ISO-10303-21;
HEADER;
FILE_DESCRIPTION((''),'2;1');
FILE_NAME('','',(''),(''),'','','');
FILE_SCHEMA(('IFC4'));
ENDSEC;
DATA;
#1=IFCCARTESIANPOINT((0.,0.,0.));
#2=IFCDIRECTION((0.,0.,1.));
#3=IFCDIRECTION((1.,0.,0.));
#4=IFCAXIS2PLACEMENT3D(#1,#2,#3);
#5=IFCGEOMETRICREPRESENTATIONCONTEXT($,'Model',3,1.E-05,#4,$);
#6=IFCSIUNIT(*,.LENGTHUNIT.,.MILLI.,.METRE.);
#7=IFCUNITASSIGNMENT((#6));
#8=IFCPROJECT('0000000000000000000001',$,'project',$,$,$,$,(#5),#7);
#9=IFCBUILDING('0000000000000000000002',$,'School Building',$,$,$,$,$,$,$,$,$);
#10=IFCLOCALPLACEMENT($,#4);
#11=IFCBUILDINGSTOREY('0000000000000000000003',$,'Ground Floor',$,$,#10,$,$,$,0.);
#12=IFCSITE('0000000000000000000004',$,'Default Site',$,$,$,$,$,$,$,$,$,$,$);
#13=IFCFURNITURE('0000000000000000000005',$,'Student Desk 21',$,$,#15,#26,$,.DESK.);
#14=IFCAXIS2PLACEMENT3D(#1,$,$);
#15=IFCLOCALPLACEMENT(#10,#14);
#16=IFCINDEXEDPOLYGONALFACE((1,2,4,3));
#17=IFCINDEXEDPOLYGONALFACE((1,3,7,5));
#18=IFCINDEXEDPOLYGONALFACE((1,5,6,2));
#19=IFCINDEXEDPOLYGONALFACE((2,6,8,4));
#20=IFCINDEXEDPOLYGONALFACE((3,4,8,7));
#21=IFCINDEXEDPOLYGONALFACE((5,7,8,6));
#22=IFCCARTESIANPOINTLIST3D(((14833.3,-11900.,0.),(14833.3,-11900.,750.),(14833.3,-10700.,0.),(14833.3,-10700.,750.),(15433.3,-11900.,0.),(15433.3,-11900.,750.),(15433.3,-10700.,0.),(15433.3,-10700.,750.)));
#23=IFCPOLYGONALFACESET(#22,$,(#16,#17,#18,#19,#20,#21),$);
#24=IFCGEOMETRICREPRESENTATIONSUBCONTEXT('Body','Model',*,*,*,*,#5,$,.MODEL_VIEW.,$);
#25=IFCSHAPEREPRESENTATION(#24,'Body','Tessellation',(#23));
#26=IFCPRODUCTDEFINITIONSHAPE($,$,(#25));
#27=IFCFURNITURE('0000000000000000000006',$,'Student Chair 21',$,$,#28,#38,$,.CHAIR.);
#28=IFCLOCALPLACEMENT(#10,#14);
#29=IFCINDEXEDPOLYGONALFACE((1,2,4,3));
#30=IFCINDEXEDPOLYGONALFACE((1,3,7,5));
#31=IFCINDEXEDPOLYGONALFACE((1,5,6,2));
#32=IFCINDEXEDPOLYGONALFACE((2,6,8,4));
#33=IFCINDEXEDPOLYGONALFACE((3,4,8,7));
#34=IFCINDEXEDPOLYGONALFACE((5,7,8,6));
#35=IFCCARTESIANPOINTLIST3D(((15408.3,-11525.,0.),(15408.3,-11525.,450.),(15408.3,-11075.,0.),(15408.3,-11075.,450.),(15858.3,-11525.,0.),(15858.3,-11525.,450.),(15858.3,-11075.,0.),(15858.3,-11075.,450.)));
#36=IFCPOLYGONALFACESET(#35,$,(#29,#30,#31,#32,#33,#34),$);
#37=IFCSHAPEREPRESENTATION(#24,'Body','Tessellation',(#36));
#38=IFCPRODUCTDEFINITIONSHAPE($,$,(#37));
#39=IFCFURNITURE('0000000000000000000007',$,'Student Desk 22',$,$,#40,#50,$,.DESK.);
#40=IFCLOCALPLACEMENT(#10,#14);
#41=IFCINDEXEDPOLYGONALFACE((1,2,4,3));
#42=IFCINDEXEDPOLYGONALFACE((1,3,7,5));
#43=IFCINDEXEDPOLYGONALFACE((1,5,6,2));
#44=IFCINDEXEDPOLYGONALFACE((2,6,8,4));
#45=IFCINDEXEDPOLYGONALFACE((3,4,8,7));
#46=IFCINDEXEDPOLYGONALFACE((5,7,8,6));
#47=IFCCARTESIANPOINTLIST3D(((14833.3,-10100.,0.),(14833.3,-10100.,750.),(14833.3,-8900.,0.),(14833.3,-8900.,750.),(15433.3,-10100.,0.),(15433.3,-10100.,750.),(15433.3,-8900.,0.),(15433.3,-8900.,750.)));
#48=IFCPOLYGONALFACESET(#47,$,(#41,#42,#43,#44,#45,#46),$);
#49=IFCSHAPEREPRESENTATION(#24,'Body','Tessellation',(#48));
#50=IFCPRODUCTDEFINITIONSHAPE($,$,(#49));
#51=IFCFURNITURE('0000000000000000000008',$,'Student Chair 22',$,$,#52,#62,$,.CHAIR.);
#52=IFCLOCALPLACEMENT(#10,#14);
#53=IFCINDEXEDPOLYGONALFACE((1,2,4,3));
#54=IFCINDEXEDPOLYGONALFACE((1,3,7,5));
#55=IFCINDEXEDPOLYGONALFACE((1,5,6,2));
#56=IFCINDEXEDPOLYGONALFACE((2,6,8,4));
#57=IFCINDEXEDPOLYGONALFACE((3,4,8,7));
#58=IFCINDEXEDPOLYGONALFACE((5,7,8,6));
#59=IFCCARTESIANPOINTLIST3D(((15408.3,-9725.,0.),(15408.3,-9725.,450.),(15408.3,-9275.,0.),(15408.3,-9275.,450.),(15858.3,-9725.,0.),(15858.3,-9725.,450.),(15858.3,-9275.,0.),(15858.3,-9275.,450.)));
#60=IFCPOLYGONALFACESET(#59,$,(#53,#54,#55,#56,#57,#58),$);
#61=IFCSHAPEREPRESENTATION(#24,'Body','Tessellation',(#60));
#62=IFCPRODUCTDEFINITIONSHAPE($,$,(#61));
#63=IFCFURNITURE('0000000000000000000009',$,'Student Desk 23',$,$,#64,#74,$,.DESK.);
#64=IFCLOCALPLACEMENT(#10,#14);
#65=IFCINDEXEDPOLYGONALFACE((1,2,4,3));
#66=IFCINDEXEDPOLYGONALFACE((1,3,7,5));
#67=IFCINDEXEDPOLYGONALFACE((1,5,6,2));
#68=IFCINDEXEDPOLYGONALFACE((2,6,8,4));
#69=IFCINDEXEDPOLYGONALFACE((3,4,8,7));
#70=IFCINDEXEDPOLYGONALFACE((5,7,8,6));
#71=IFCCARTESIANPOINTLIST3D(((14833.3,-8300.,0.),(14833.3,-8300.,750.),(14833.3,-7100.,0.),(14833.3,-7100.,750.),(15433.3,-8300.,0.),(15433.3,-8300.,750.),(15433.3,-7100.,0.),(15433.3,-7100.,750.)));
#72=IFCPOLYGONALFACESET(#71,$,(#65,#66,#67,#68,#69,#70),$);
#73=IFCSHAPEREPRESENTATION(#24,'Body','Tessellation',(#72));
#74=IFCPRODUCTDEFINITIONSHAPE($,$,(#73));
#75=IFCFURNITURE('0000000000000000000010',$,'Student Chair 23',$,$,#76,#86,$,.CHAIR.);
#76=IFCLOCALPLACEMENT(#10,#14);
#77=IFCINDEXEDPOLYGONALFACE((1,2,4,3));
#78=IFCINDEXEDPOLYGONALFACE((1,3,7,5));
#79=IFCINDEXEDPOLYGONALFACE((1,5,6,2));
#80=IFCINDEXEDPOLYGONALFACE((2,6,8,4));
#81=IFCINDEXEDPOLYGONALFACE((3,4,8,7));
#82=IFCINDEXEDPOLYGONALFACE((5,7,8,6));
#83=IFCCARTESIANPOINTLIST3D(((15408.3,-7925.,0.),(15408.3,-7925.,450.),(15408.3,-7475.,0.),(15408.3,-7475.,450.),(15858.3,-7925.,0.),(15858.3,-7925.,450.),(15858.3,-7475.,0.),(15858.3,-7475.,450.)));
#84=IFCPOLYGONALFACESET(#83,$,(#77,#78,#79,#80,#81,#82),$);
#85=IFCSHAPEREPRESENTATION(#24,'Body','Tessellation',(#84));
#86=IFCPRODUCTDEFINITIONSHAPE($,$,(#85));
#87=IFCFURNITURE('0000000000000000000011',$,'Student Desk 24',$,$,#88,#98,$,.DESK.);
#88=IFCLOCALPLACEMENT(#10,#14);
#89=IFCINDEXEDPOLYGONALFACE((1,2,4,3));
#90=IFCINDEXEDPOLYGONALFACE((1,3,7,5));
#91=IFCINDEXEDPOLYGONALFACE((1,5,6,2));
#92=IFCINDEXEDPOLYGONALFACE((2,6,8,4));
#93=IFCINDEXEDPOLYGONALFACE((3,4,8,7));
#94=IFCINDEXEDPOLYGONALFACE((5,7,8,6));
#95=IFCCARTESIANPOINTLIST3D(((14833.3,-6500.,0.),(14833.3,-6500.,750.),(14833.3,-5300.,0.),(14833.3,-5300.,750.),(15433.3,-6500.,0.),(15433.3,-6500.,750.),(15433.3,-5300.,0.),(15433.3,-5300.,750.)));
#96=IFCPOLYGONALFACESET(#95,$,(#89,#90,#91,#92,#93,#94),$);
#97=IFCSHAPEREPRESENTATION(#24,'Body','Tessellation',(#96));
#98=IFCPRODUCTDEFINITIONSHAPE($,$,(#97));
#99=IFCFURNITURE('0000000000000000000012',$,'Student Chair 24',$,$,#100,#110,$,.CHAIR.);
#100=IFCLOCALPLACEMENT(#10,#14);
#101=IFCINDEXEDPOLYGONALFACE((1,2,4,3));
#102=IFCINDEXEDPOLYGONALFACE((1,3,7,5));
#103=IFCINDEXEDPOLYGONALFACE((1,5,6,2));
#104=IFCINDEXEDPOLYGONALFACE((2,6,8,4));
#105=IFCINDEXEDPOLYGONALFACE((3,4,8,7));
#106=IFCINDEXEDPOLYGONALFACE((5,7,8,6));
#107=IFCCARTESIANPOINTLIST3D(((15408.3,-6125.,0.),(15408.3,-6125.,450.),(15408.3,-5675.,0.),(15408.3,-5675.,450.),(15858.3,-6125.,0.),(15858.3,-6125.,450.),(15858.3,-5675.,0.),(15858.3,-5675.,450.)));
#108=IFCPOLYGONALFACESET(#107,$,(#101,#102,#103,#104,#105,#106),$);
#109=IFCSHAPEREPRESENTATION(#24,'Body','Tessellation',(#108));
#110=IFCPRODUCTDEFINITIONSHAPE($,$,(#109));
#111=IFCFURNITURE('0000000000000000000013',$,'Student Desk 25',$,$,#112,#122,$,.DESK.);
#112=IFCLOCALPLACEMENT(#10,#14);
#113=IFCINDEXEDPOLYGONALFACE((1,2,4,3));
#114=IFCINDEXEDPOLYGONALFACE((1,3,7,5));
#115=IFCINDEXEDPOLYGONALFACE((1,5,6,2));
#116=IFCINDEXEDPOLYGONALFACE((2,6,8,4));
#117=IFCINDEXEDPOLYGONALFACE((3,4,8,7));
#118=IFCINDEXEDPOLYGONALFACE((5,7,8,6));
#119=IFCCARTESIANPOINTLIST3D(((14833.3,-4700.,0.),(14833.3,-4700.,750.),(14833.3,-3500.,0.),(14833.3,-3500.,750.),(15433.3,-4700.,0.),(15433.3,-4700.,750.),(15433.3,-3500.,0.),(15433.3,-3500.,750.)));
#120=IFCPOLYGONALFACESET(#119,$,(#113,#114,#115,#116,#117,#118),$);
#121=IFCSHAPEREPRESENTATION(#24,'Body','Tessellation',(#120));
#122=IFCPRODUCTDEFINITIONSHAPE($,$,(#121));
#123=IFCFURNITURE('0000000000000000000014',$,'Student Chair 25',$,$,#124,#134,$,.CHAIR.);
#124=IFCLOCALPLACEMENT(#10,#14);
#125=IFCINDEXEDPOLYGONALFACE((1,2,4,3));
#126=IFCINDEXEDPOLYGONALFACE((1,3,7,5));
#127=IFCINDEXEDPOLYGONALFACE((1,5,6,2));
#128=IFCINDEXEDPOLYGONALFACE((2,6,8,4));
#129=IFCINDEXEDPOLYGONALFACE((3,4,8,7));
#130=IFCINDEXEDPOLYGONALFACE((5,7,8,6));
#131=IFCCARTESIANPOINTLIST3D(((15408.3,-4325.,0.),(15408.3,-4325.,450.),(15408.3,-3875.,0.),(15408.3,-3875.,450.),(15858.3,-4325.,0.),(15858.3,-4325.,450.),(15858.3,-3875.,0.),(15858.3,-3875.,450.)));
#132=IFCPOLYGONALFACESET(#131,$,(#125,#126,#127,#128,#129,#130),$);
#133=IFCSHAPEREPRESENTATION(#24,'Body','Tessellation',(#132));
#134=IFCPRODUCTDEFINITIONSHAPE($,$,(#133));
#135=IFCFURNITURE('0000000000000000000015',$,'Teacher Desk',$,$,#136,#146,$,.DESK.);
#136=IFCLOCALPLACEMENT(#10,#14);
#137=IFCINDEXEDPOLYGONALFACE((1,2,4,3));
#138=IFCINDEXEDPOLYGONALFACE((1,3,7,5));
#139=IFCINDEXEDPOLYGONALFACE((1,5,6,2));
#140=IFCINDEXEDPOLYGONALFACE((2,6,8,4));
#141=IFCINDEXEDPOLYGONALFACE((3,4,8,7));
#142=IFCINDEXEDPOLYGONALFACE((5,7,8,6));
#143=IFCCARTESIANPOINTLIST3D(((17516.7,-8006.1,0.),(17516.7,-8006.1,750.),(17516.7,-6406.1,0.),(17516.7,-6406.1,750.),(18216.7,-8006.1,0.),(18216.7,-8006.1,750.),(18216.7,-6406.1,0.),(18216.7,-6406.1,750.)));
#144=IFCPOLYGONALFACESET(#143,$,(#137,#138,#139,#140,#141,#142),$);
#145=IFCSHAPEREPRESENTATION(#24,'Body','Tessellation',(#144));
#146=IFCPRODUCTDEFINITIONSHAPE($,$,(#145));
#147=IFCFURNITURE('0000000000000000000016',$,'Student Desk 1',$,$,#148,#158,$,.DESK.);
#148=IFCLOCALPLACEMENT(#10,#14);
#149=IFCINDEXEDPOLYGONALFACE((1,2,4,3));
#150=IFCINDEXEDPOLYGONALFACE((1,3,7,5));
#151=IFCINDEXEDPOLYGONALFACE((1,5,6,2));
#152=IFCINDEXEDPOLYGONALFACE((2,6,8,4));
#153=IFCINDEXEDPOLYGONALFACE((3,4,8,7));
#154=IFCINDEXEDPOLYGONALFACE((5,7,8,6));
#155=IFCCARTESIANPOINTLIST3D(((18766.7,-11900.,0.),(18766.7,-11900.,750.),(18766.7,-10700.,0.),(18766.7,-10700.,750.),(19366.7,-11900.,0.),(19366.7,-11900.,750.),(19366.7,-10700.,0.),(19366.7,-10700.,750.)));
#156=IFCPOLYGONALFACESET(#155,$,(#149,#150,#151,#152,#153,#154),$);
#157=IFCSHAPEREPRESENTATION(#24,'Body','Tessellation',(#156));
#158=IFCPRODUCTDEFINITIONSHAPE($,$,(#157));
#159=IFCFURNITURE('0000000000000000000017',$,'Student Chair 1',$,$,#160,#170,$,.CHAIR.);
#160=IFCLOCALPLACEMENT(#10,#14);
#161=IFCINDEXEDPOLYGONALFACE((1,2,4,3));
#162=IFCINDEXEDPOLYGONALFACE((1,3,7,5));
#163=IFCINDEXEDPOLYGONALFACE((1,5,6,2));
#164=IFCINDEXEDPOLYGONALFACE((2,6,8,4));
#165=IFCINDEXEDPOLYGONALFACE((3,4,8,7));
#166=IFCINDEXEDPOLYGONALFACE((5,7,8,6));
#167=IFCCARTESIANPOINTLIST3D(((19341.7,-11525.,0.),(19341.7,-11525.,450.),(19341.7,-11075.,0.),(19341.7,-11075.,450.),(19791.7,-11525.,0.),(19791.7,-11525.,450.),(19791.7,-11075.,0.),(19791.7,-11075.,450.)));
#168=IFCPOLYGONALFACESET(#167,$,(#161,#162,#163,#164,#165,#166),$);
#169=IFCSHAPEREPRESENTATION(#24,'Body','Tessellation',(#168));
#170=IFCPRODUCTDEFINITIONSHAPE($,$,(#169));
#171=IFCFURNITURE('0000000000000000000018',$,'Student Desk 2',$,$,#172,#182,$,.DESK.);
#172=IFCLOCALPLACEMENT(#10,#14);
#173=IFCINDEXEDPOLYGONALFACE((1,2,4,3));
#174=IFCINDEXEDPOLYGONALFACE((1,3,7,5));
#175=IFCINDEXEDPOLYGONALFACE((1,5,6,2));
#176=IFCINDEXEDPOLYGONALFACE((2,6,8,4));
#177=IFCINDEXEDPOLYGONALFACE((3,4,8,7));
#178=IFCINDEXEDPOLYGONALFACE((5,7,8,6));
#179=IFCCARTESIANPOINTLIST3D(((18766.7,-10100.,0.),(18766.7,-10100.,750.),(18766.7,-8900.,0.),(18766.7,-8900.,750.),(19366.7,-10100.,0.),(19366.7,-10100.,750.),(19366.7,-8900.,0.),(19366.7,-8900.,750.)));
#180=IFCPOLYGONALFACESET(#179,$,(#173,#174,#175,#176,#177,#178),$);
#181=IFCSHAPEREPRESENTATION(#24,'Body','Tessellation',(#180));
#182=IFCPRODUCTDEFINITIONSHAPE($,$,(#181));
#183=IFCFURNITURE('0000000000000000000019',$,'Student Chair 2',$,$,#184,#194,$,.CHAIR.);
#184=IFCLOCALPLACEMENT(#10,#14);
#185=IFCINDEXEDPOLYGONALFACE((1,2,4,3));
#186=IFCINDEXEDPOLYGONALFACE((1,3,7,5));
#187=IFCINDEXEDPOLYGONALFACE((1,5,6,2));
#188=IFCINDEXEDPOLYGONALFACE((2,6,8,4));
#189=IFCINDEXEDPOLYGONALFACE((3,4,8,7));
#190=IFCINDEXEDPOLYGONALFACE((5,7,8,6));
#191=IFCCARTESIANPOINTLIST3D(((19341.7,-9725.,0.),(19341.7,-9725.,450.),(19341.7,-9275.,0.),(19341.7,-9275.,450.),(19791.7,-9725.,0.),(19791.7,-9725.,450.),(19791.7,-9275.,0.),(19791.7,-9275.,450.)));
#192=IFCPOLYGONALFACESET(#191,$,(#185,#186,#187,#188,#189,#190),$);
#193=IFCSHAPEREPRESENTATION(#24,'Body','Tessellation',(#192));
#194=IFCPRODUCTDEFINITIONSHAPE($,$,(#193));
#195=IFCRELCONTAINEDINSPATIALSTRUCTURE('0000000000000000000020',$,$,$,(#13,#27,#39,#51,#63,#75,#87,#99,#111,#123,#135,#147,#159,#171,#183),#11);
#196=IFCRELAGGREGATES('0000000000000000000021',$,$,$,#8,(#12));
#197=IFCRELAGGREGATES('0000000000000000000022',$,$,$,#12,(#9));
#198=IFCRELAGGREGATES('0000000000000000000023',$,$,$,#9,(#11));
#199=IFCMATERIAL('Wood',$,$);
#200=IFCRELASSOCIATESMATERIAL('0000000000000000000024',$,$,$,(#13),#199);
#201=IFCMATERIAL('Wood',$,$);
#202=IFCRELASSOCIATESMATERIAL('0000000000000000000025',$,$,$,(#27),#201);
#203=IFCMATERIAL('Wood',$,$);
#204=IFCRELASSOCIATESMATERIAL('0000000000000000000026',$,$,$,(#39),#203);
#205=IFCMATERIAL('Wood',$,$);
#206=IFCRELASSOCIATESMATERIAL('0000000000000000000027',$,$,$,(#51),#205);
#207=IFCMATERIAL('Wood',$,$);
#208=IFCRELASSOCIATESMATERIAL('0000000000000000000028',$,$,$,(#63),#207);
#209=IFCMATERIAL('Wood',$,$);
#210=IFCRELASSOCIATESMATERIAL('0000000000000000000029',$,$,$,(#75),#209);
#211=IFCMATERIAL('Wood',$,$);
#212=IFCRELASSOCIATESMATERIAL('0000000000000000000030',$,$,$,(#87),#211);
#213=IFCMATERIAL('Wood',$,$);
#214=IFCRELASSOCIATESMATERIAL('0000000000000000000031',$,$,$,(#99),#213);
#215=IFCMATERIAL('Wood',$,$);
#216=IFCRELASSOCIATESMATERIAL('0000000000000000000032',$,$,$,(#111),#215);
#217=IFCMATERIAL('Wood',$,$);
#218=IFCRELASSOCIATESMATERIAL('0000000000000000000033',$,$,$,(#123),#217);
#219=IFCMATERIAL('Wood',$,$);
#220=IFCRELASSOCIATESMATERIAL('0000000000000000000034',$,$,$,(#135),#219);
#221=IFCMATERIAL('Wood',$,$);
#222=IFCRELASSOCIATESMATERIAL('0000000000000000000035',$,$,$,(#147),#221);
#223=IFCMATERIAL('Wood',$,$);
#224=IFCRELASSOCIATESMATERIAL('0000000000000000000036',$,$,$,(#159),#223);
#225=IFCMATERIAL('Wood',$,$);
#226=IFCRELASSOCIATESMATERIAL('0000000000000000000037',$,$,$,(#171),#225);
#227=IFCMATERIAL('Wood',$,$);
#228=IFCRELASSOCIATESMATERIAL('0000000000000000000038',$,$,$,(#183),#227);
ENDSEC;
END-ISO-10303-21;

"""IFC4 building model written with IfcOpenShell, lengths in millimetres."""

from ifc_helpers import new_model, si_unit, frame, origin_with_axes, origin_2d, place, context, subcontext, project, spatial, rectangle, extrude, material, element, save


model = new_model("IFC4")

# Units and contexts
model_context = context("Model", 3, precision=1e-05, world=origin_with_axes())
body_context = subcontext(model_context, "Body", "Model", "MODEL_VIEW")
ifc_project = project(units=[si_unit("LENGTHUNIT", "METRE", prefix="MILLI")], contexts=[model_context])

# Site, building, storey
site = spatial("IfcSite", under=ifc_project, Name="Default Site")
building = spatial("IfcBuilding", under=site, Name="School Building")
storey_placement = place(None, origin_with_axes())
storey = spatial("IfcBuildingStorey", under=building, at=storey_placement, Name="Ground Floor", Elevation=0.0)

# Furniture
ifc_material_1 = material(Name="Wood")
furniture_1_placement = place(storey_placement, frame((15133.3, -11300.0, 0.0), z_axis=(0.0, 0.0, 1.0), x_axis=(0.0, 1.0, 0.0)))
element("IfcFurniture", 1, at=furniture_1_placement, inside=storey, material=ifc_material_1, Name="Student Desk 21", PredefinedType="DESK", context=body_context, shape_type="SweptSolid", body=[
    extrude(rectangle(XDim=1200.0, YDim=600.0, at=origin_2d()), origin_with_axes(), (0.0, 0.0, 1.0), 750.0),
])
ifc_material_2 = material(Name="Wood")
furniture_2_placement = place(storey_placement, frame((15633.3, -11300.0, 0.0), z_axis=(0.0, 0.0, 1.0), x_axis=(1.0, 0.0, 0.0)))
element("IfcFurniture", 2, at=furniture_2_placement, inside=storey, material=ifc_material_2, Name="Student Chair 21", PredefinedType="CHAIR", context=body_context, shape_type="SweptSolid", body=[
    extrude(rectangle(XDim=450.0, YDim=450.0, at=origin_2d()), origin_with_axes(), (0.0, 0.0, 1.0), 450.0),
])
ifc_material_3 = material(Name="Wood")
furniture_3_placement = place(storey_placement, frame((15133.3, -9500.0, 0.0), z_axis=(0.0, 0.0, 1.0), x_axis=(0.0, 1.0, 0.0)))
element("IfcFurniture", 3, at=furniture_3_placement, inside=storey, material=ifc_material_3, Name="Student Desk 22", PredefinedType="DESK", context=body_context, shape_type="SweptSolid", body=[
    extrude(rectangle(XDim=1200.0, YDim=600.0, at=origin_2d()), origin_with_axes(), (0.0, 0.0, 1.0), 750.0),
])
ifc_material_4 = material(Name="Wood")
furniture_4_placement = place(storey_placement, frame((15633.3, -9500.0, 0.0), z_axis=(0.0, 0.0, 1.0), x_axis=(1.0, 0.0, 0.0)))
element("IfcFurniture", 4, at=furniture_4_placement, inside=storey, material=ifc_material_4, Name="Student Chair 22", PredefinedType="CHAIR", context=body_context, shape_type="SweptSolid", body=[
    extrude(rectangle(XDim=450.0, YDim=450.0, at=origin_2d()), origin_with_axes(), (0.0, 0.0, 1.0), 450.0),
])
ifc_material_5 = material(Name="Wood")
furniture_5_placement = place(storey_placement, frame((15133.3, -7700.0, 0.0), z_axis=(0.0, 0.0, 1.0), x_axis=(0.0, 1.0, 0.0)))
element("IfcFurniture", 5, at=furniture_5_placement, inside=storey, material=ifc_material_5, Name="Student Desk 23", PredefinedType="DESK", context=body_context, shape_type="SweptSolid", body=[
    extrude(rectangle(XDim=1200.0, YDim=600.0, at=origin_2d()), origin_with_axes(), (0.0, 0.0, 1.0), 750.0),
])
ifc_material_6 = material(Name="Wood")
furniture_6_placement = place(storey_placement, frame((15633.3, -7700.0, 0.0), z_axis=(0.0, 0.0, 1.0), x_axis=(1.0, 0.0, 0.0)))
element("IfcFurniture", 6, at=furniture_6_placement, inside=storey, material=ifc_material_6, Name="Student Chair 23", PredefinedType="CHAIR", context=body_context, shape_type="SweptSolid", body=[
    extrude(rectangle(XDim=450.0, YDim=450.0, at=origin_2d()), origin_with_axes(), (0.0, 0.0, 1.0), 450.0),
])
ifc_material_7 = material(Name="Wood")
furniture_7_placement = place(storey_placement, frame((15133.3, -5900.0, 0.0), z_axis=(0.0, 0.0, 1.0), x_axis=(0.0, 1.0, 0.0)))
element("IfcFurniture", 7, at=furniture_7_placement, inside=storey, material=ifc_material_7, Name="Student Desk 24", PredefinedType="DESK", context=body_context, shape_type="SweptSolid", body=[
    extrude(rectangle(XDim=1200.0, YDim=600.0, at=origin_2d()), origin_with_axes(), (0.0, 0.0, 1.0), 750.0),
])
ifc_material_8 = material(Name="Wood")
furniture_8_placement = place(storey_placement, frame((15633.3, -5900.0, 0.0), z_axis=(0.0, 0.0, 1.0), x_axis=(1.0, 0.0, 0.0)))
element("IfcFurniture", 8, at=furniture_8_placement, inside=storey, material=ifc_material_8, Name="Student Chair 24", PredefinedType="CHAIR", context=body_context, shape_type="SweptSolid", body=[
    extrude(rectangle(XDim=450.0, YDim=450.0, at=origin_2d()), origin_with_axes(), (0.0, 0.0, 1.0), 450.0),
])
ifc_material_9 = material(Name="Wood")
furniture_9_placement = place(storey_placement, frame((15133.3, -4100.0, 0.0), z_axis=(0.0, 0.0, 1.0), x_axis=(0.0, 1.0, 0.0)))
element("IfcFurniture", 9, at=furniture_9_placement, inside=storey, material=ifc_material_9, Name="Student Desk 25", PredefinedType="DESK", context=body_context, shape_type="SweptSolid", body=[
    extrude(rectangle(XDim=1200.0, YDim=600.0, at=origin_2d()), origin_with_axes(), (0.0, 0.0, 1.0), 750.0),
])
ifc_material_10 = material(Name="Wood")
furniture_10_placement = place(storey_placement, frame((15633.3, -4100.0, 0.0), z_axis=(0.0, 0.0, 1.0), x_axis=(1.0, 0.0, 0.0)))
element("IfcFurniture", 10, at=furniture_10_placement, inside=storey, material=ifc_material_10, Name="Student Chair 25", PredefinedType="CHAIR", context=body_context, shape_type="SweptSolid", body=[
    extrude(rectangle(XDim=450.0, YDim=450.0, at=origin_2d()), origin_with_axes(), (0.0, 0.0, 1.0), 450.0),
])
ifc_material_11 = material(Name="Wood")
furniture_11_placement = place(storey_placement, frame((17866.7, -7206.1, 0.0), z_axis=(0.0, 0.0, 1.0), x_axis=(0.0, 1.0, 0.0)))
element("IfcFurniture", 11, at=furniture_11_placement, inside=storey, material=ifc_material_11, Name="Teacher Desk", PredefinedType="DESK", context=body_context, shape_type="SweptSolid", body=[
    extrude(rectangle(XDim=1600.0, YDim=700.0, at=origin_2d()), origin_with_axes(), (0.0, 0.0, 1.0), 750.0),
])
ifc_material_12 = material(Name="Wood")
furniture_12_placement = place(storey_placement, frame((19066.7, -11300.0, 0.0), z_axis=(0.0, 0.0, 1.0), x_axis=(0.0, 1.0, 0.0)))
element("IfcFurniture", 12, at=furniture_12_placement, inside=storey, material=ifc_material_12, Name="Student Desk 1", PredefinedType="DESK", context=body_context, shape_type="SweptSolid", body=[
    extrude(rectangle(XDim=1200.0, YDim=600.0, at=origin_2d()), origin_with_axes(), (0.0, 0.0, 1.0), 750.0),
])
ifc_material_13 = material(Name="Wood")
furniture_13_placement = place(storey_placement, frame((19566.7, -11300.0, 0.0), z_axis=(0.0, 0.0, 1.0), x_axis=(1.0, 0.0, 0.0)))
element("IfcFurniture", 13, at=furniture_13_placement, inside=storey, material=ifc_material_13, Name="Student Chair 1", PredefinedType="CHAIR", context=body_context, shape_type="SweptSolid", body=[
    extrude(rectangle(XDim=450.0, YDim=450.0, at=origin_2d()), origin_with_axes(), (0.0, 0.0, 1.0), 450.0),
])
ifc_material_14 = material(Name="Wood")
furniture_14_placement = place(storey_placement, frame((19066.7, -9500.0, 0.0), z_axis=(0.0, 0.0, 1.0), x_axis=(0.0, 1.0, 0.0)))
element("IfcFurniture", 14, at=furniture_14_placement, inside=storey, material=ifc_material_14, Name="Student Desk 2", PredefinedType="DESK", context=body_context, shape_type="SweptSolid", body=[
    extrude(rectangle(XDim=1200.0, YDim=600.0, at=origin_2d()), origin_with_axes(), (0.0, 0.0, 1.0), 750.0),
])
ifc_material_15 = material(Name="Wood")
furniture_15_placement = place(storey_placement, frame((19566.7, -9500.0, 0.0), z_axis=(0.0, 0.0, 1.0), x_axis=(1.0, 0.0, 0.0)))
element("IfcFurniture", 15, at=furniture_15_placement, inside=storey, material=ifc_material_15, Name="Student Chair 2", PredefinedType="CHAIR", context=body_context, shape_type="SweptSolid", body=[
    extrude(rectangle(XDim=450.0, YDim=450.0, at=origin_2d()), origin_with_axes(), (0.0, 0.0, 1.0), 450.0),
])

save(model, "model.ifc")
